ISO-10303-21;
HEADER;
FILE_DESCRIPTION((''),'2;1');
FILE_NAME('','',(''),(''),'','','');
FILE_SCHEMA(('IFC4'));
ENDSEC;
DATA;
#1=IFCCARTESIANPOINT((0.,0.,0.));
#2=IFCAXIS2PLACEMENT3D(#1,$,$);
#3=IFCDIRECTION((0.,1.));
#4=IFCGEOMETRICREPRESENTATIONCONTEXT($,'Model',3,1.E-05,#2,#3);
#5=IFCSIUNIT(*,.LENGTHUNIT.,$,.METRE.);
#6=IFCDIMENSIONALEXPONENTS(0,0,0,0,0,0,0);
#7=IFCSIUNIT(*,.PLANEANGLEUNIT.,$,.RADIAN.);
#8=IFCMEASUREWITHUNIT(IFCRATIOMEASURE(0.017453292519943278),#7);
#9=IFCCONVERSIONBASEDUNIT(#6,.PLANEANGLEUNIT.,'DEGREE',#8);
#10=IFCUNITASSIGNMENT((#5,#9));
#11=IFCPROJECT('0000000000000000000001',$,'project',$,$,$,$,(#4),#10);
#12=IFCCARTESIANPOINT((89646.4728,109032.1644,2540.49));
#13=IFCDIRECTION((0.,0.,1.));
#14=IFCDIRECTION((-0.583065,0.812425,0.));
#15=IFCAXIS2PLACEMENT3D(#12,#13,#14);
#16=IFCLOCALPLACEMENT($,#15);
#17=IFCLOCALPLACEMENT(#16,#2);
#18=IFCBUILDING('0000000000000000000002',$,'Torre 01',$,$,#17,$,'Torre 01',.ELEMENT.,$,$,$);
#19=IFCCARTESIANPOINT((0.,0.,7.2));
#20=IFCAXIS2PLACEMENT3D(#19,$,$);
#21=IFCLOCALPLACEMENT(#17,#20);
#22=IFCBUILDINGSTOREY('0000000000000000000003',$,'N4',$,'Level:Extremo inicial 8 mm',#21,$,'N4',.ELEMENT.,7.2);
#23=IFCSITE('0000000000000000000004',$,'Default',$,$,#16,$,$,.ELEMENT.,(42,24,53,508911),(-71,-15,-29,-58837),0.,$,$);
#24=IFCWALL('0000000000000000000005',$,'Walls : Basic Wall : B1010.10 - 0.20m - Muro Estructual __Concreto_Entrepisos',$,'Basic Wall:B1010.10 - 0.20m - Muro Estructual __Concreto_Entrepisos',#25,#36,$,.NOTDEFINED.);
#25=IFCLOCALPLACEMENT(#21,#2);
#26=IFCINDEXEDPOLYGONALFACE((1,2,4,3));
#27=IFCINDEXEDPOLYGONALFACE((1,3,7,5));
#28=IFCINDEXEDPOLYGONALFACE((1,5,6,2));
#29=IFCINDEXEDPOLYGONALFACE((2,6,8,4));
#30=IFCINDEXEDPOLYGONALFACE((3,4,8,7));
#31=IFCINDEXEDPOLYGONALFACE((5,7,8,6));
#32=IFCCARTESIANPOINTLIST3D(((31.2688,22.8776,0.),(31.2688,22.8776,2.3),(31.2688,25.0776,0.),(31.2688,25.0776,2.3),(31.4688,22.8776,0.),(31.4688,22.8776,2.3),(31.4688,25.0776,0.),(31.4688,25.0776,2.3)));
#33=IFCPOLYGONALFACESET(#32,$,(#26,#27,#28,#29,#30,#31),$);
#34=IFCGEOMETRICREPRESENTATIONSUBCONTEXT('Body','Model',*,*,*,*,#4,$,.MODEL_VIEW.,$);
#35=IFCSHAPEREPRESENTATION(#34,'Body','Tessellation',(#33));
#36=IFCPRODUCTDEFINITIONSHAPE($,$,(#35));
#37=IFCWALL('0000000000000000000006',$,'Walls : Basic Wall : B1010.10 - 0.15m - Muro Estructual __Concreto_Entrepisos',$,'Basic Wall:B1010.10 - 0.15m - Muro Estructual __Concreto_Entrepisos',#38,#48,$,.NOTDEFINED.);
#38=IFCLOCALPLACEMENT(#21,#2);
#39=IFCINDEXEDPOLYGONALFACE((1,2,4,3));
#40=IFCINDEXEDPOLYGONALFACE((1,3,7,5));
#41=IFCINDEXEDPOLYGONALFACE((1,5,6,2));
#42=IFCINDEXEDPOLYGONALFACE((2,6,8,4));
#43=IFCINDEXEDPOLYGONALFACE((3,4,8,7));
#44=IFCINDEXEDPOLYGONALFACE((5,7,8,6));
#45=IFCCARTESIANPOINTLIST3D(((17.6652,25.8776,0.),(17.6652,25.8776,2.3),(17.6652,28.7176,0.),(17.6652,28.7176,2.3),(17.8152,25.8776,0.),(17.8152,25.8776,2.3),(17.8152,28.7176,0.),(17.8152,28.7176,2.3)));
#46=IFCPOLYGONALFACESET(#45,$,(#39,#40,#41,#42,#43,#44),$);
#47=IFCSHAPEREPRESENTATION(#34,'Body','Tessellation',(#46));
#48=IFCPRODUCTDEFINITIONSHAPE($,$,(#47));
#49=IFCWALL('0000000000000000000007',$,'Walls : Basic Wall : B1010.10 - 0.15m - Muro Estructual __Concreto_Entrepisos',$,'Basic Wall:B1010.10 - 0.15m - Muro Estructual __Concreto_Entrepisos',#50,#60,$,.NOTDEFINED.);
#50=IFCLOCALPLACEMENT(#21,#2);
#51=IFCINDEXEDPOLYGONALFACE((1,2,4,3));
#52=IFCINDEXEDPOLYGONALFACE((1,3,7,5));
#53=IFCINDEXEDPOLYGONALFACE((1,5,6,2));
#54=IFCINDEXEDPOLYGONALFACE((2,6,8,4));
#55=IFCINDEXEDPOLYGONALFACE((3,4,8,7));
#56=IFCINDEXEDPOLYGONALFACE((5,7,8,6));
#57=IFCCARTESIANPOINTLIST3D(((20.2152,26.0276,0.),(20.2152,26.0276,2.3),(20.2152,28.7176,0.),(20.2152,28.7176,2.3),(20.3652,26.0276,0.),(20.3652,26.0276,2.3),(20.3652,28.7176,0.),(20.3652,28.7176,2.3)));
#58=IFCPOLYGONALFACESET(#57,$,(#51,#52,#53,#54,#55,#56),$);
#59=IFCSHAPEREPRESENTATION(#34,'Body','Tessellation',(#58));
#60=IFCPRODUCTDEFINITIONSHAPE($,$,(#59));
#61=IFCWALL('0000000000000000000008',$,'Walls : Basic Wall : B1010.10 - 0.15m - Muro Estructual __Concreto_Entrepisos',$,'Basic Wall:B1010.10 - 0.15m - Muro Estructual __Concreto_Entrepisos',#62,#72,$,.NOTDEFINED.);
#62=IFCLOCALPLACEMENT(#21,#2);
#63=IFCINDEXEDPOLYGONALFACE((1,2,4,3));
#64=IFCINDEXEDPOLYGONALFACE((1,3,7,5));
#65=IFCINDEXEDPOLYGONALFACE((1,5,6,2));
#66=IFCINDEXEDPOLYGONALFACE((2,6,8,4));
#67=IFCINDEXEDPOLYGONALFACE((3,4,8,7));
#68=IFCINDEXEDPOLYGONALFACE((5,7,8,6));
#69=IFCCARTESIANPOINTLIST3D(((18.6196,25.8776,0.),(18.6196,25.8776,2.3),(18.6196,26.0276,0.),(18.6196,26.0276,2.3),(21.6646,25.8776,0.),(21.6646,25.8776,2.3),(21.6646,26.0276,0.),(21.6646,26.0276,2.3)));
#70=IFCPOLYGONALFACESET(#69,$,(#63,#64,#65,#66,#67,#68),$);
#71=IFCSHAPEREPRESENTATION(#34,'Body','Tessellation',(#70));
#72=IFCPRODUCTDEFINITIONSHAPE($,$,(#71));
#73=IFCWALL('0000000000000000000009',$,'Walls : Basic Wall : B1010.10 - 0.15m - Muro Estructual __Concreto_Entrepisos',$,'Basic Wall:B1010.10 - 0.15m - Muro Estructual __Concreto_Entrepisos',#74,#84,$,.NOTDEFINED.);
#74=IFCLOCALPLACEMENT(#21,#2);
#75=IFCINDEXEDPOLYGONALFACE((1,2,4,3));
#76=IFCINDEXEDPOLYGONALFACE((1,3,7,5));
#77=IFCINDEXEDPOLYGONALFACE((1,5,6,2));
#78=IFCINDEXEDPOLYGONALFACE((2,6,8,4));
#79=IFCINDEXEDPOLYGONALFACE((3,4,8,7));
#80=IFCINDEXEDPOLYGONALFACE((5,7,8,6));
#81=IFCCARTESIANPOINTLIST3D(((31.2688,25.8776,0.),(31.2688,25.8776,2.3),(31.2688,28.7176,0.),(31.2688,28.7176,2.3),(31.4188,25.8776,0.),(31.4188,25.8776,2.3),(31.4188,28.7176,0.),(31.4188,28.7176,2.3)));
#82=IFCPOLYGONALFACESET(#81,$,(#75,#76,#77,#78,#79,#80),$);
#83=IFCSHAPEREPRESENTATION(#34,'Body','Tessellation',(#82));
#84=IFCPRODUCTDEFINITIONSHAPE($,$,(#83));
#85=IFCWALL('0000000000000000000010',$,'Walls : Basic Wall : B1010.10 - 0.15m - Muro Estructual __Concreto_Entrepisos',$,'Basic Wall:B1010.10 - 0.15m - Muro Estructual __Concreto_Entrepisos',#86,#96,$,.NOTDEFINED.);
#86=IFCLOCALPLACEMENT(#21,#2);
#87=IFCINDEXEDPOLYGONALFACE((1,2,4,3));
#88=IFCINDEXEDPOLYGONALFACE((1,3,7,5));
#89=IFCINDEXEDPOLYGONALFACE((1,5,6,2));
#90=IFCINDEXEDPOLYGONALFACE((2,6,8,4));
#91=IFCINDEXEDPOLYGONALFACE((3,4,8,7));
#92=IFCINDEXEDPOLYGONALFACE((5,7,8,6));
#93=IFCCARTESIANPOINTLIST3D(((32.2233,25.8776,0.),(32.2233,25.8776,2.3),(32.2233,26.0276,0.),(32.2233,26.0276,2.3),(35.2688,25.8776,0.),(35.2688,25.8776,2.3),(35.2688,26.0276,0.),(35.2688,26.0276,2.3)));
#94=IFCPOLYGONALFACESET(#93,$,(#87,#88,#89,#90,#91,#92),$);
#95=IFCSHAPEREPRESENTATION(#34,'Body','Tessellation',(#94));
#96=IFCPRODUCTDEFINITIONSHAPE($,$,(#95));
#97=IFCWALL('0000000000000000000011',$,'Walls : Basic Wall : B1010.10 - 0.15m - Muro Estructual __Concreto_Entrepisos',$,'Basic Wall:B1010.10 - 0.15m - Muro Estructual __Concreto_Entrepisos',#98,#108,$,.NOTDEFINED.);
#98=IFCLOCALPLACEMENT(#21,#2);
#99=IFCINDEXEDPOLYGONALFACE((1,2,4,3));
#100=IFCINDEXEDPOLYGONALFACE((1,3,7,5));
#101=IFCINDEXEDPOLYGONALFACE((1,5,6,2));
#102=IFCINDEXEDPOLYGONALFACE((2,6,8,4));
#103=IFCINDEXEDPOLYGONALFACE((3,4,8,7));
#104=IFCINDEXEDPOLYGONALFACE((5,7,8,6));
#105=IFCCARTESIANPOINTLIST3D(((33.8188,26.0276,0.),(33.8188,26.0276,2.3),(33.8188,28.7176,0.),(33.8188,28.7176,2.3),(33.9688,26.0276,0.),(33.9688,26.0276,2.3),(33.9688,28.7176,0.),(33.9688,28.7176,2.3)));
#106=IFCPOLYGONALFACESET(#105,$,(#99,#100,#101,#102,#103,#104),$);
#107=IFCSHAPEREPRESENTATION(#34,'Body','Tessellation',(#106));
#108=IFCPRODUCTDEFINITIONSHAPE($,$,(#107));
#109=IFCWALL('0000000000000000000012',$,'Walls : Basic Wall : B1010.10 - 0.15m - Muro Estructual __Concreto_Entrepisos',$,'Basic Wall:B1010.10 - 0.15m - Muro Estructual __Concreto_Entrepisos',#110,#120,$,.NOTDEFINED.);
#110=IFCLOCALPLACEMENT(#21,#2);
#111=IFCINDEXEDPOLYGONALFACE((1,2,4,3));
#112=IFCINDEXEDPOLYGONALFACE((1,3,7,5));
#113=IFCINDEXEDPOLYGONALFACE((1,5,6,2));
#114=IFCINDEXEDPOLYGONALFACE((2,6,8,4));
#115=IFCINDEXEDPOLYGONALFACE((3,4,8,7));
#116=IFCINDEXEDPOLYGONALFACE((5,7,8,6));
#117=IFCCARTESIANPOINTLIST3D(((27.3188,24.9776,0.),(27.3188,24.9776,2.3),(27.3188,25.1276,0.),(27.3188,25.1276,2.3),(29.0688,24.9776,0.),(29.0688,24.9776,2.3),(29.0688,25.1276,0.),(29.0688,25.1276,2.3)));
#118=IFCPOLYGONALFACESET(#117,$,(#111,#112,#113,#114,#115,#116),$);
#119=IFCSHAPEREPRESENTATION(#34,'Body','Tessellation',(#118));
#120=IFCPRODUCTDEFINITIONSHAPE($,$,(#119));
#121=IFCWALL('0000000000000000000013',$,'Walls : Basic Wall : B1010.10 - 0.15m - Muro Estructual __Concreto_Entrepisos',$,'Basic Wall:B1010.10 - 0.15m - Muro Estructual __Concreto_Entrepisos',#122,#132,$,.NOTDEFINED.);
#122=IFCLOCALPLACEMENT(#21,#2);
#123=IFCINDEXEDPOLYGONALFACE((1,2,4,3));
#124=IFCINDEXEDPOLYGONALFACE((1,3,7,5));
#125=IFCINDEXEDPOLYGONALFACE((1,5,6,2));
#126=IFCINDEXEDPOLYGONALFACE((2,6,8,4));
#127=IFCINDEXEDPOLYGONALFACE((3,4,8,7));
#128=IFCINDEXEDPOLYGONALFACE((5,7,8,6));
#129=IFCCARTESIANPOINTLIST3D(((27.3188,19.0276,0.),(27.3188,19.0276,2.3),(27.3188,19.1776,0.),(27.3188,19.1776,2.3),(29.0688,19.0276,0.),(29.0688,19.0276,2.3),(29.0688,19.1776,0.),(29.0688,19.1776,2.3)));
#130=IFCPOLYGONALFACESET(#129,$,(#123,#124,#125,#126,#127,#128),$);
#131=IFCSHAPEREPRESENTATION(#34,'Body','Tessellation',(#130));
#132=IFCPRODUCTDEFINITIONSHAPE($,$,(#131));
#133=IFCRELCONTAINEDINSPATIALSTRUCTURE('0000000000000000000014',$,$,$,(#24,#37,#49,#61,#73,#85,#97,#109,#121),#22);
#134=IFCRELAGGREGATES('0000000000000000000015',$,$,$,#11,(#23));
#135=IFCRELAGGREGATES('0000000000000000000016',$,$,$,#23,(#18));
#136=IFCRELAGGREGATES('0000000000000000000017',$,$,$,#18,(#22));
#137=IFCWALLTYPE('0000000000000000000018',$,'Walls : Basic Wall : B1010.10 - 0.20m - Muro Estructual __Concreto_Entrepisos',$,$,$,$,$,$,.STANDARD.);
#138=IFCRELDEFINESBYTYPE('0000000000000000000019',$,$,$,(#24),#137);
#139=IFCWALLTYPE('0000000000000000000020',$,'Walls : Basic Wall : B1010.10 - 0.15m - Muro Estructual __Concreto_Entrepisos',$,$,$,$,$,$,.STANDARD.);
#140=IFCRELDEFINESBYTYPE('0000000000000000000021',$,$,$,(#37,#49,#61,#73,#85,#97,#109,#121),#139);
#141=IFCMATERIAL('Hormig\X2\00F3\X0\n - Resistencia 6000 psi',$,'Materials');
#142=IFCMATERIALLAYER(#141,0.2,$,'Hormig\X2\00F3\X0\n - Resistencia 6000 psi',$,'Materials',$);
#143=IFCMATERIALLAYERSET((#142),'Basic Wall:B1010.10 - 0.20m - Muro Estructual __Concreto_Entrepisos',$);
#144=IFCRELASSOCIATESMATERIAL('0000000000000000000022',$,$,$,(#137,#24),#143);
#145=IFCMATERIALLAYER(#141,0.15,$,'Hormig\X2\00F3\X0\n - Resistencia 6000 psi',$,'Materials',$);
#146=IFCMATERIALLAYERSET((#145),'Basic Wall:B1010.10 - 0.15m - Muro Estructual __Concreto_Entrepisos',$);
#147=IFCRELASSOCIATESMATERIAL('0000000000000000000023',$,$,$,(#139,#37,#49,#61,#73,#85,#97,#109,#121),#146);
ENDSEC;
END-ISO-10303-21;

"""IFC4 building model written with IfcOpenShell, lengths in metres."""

from ifc_helpers import new_model, entity, si_unit, converted_unit, direction, frame, frame_2d, origin, place, context, subcontext, project, spatial, rectangle, extrude, material, layer, layer_set, layer_usage, type_object, element, save


model = new_model("IFC4")

# Units and contexts
model_context = context("Model", 3, precision=1e-05, world=origin(), true_north=direction((0.0, 1.0)))
body_context = subcontext(model_context, "Body", "Model", "MODEL_VIEW")
ifc_project = project(units=[si_unit("LENGTHUNIT", "METRE"), converted_unit("PLANEANGLEUNIT", "DEGREE", entity("IfcRatioMeasure", 0.017453292519943278), si_unit("PLANEANGLEUNIT", "RADIAN"), dimensions=[0, 0, 0, 0, 0, 0, 0])], contexts=[model_context])

# Site, building, storey
site_placement = place(None, frame((89646.4728, 109032.1644, 2540.49), z_axis=(0.0, 0.0, 1.0), x_axis=(-0.583065, 0.812425, 0.0)))
site = spatial("IfcSite", under=ifc_project, at=site_placement, Name="Default", CompositionType="ELEMENT", RefLatitude=(42, 24, 53, 508911), RefLongitude=(-71, -15, -29, -58837), RefElevation=0.0)
building_placement = place(site_placement, origin())
building = spatial("IfcBuilding", under=site, at=building_placement, Name="Torre 01", LongName="Torre 01", CompositionType="ELEMENT")
storey_placement = place(building_placement, frame((0.0, 0.0, 7.2)))
storey = spatial("IfcBuildingStorey", under=building, at=storey_placement, Name="N4", ObjectType="Level:Extremo inicial 8 mm", LongName="N4", CompositionType="ELEMENT", Elevation=7.2)

# Walls
ifc_material = material(Name="Hormigón - Resistencia 6000 psi", Category="Materials")
ifc_layer_1 = layer(ifc_material, 0.2, Name="Hormigón - Resistencia 6000 psi", Category="Materials")
ifc_layer_set_1 = layer_set([ifc_layer_1], Name="Basic Wall:B1010.10 - 0.20m - Muro Estructual __Concreto_Entrepisos")
wall_type_1 = type_object("IfcWallType", Name="Walls : Basic Wall : B1010.10 - 0.20m - Muro Estructual __Concreto_Entrepisos", PredefinedType="STANDARD", material=ifc_layer_set_1)
ifc_layer_usage_1 = layer_usage(ifc_layer_set_1, "AXIS2", "POSITIVE", -0.1)
wall_1_placement = place(storey_placement, frame((31.3688, 22.8776, 0.0), z_axis=(0.0, 0.0, 1.0), x_axis=(0.0, 1.0, 0.0)))
element("IfcWall", 1, at=wall_1_placement, inside=storey, type_object=wall_type_1, material=ifc_layer_usage_1, Name="Walls : Basic Wall : B1010.10 - 0.20m - Muro Estructual __Concreto_Entrepisos", ObjectType="Basic Wall:B1010.10 - 0.20m - Muro Estructual __Concreto_Entrepisos", PredefinedType="NOTDEFINED", context=body_context, shape_type="SweptSolid", body=[
    extrude(rectangle(XDim=2.2, YDim=0.2, at=frame_2d((1.1, 0.0), x_axis=(-1.0, 0.0))), origin(), (0.0, 0.0, 1.0), 2.3),
])
ifc_layer_2 = layer(ifc_material, 0.15, Name="Hormigón - Resistencia 6000 psi", Category="Materials")
ifc_layer_set_2 = layer_set([ifc_layer_2], Name="Basic Wall:B1010.10 - 0.15m - Muro Estructual __Concreto_Entrepisos")
ifc_layer_usage_2 = layer_usage(ifc_layer_set_2, "AXIS2", "POSITIVE", -0.075)
wall_type_2 = type_object("IfcWallType", Name="Walls : Basic Wall : B1010.10 - 0.15m - Muro Estructual __Concreto_Entrepisos", PredefinedType="STANDARD", material=ifc_layer_set_2)
wall_2_placement = place(storey_placement, frame((17.7402, 25.8776, 0.0), z_axis=(0.0, 0.0, 1.0), x_axis=(0.0, 1.0, 0.0)))
element("IfcWall", 2, at=wall_2_placement, inside=storey, type_object=wall_type_2, material=ifc_layer_usage_2, Name="Walls : Basic Wall : B1010.10 - 0.15m - Muro Estructual __Concreto_Entrepisos", ObjectType="Basic Wall:B1010.10 - 0.15m - Muro Estructual __Concreto_Entrepisos", PredefinedType="NOTDEFINED", context=body_context, shape_type="SweptSolid", body=[
    extrude(rectangle(XDim=2.84, YDim=0.15, at=frame_2d((1.42, 0.0), x_axis=(-1.0, 0.0))), origin(), (0.0, 0.0, 1.0), 2.3),
])
ifc_layer_usage_3 = layer_usage(ifc_layer_set_2, "AXIS2", "POSITIVE", -0.075)
wall_3_placement = place(storey_placement, frame((20.2902, 28.7176, 0.0), z_axis=(0.0, 0.0, 1.0), x_axis=(0.0, -1.0, 0.0)))
element("IfcWall", 3, at=wall_3_placement, inside=storey, type_object=wall_type_2, material=ifc_layer_usage_3, Name="Walls : Basic Wall : B1010.10 - 0.15m - Muro Estructual __Concreto_Entrepisos", ObjectType="Basic Wall:B1010.10 - 0.15m - Muro Estructual __Concreto_Entrepisos", PredefinedType="NOTDEFINED", context=body_context, shape_type="SweptSolid", body=[
    extrude(rectangle(XDim=2.69, YDim=0.15, at=frame_2d((1.345, 0.0), x_axis=(-1.0, 0.0))), origin(), (0.0, 0.0, 1.0), 2.3),
])
ifc_layer_usage_4 = layer_usage(ifc_layer_set_2, "AXIS2", "POSITIVE", -0.075)
wall_4_placement = place(storey_placement, frame((18.6196, 25.9526, 0.0)))
element("IfcWall", 4, at=wall_4_placement, inside=storey, type_object=wall_type_2, material=ifc_layer_usage_4, Name="Walls : Basic Wall : B1010.10 - 0.15m - Muro Estructual __Concreto_Entrepisos", ObjectType="Basic Wall:B1010.10 - 0.15m - Muro Estructual __Concreto_Entrepisos", PredefinedType="NOTDEFINED", context=body_context, shape_type="SweptSolid", body=[
    extrude(rectangle(XDim=3.045, YDim=0.15, at=frame_2d((1.5225, 0.0), x_axis=(-1.0, 0.0))), origin(), (0.0, 0.0, 1.0), 2.3),
])
ifc_layer_usage_5 = layer_usage(ifc_layer_set_2, "AXIS2", "POSITIVE", -0.075)
wall_5_placement = place(storey_placement, frame((31.3438, 28.7176, 0.0), z_axis=(0.0, 0.0, 1.0), x_axis=(0.0, -1.0, 0.0)))
element("IfcWall", 5, at=wall_5_placement, inside=storey, type_object=wall_type_2, material=ifc_layer_usage_5, Name="Walls : Basic Wall : B1010.10 - 0.15m - Muro Estructual __Concreto_Entrepisos", ObjectType="Basic Wall:B1010.10 - 0.15m - Muro Estructual __Concreto_Entrepisos", PredefinedType="NOTDEFINED", context=body_context, shape_type="SweptSolid", body=[
    extrude(rectangle(XDim=2.84, YDim=0.15, at=frame_2d((1.42, 0.0), x_axis=(-1.0, 0.0))), origin(), (0.0, 0.0, 1.0), 2.3),
])
ifc_layer_usage_6 = layer_usage(ifc_layer_set_2, "AXIS2", "POSITIVE", -0.075)
wall_6_placement = place(storey_placement, frame((32.2233, 25.9526, 0.0)))
element("IfcWall", 6, at=wall_6_placement, inside=storey, type_object=wall_type_2, material=ifc_layer_usage_6, Name="Walls : Basic Wall : B1010.10 - 0.15m - Muro Estructual __Concreto_Entrepisos", ObjectType="Basic Wall:B1010.10 - 0.15m - Muro Estructual __Concreto_Entrepisos", PredefinedType="NOTDEFINED", context=body_context, shape_type="SweptSolid", body=[
    extrude(rectangle(XDim=3.0455, YDim=0.15, at=frame_2d((1.5228, 0.0), x_axis=(-1.0, 0.0))), origin(), (0.0, 0.0, 1.0), 2.3),
])
ifc_layer_usage_7 = layer_usage(ifc_layer_set_2, "AXIS2", "POSITIVE", -0.075)
wall_7_placement = place(storey_placement, frame((33.8938, 26.0276, 0.0), z_axis=(0.0, 0.0, 1.0), x_axis=(0.0, 1.0, 0.0)))
element("IfcWall", 7, at=wall_7_placement, inside=storey, type_object=wall_type_2, material=ifc_layer_usage_7, Name="Walls : Basic Wall : B1010.10 - 0.15m - Muro Estructual __Concreto_Entrepisos", ObjectType="Basic Wall:B1010.10 - 0.15m - Muro Estructual __Concreto_Entrepisos", PredefinedType="NOTDEFINED", context=body_context, shape_type="SweptSolid", body=[
    extrude(rectangle(XDim=2.69, YDim=0.15, at=frame_2d((1.345, 0.0), x_axis=(-1.0, 0.0))), origin(), (0.0, 0.0, 1.0), 2.3),
])
ifc_layer_usage_8 = layer_usage(ifc_layer_set_2, "AXIS2", "NEGATIVE", 0.075)
wall_8_placement = place(storey_placement, frame((29.0688, 25.0526, 0.0), z_axis=(0.0, 0.0, 1.0), x_axis=(-1.0, 0.0, 0.0)))
element("IfcWall", 8, at=wall_8_placement, inside=storey, type_object=wall_type_2, material=ifc_layer_usage_8, Name="Walls : Basic Wall : B1010.10 - 0.15m - Muro Estructual __Concreto_Entrepisos", ObjectType="Basic Wall:B1010.10 - 0.15m - Muro Estructual __Concreto_Entrepisos", PredefinedType="NOTDEFINED", context=body_context, shape_type="SweptSolid", body=[
    extrude(rectangle(XDim=1.75, YDim=0.15, at=frame_2d((0.875, 0.0), x_axis=(-1.0, 0.0))), origin(), (0.0, 0.0, 1.0), 2.3),
])
ifc_layer_usage_9 = layer_usage(ifc_layer_set_2, "AXIS2", "POSITIVE", -0.075)
wall_9_placement = place(storey_placement, frame((29.0688, 19.1026, 0.0), z_axis=(0.0, 0.0, 1.0), x_axis=(-1.0, 0.0, 0.0)))
element("IfcWall", 9, at=wall_9_placement, inside=storey, type_object=wall_type_2, material=ifc_layer_usage_9, Name="Walls : Basic Wall : B1010.10 - 0.15m - Muro Estructual __Concreto_Entrepisos", ObjectType="Basic Wall:B1010.10 - 0.15m - Muro Estructual __Concreto_Entrepisos", PredefinedType="NOTDEFINED", context=body_context, shape_type="SweptSolid", body=[
    extrude(rectangle(XDim=1.75, YDim=0.15, at=frame_2d((0.875, 0.0), x_axis=(-1.0, 0.0))), origin(), (0.0, 0.0, 1.0), 2.3),
])

save(model, "model.ifc")
